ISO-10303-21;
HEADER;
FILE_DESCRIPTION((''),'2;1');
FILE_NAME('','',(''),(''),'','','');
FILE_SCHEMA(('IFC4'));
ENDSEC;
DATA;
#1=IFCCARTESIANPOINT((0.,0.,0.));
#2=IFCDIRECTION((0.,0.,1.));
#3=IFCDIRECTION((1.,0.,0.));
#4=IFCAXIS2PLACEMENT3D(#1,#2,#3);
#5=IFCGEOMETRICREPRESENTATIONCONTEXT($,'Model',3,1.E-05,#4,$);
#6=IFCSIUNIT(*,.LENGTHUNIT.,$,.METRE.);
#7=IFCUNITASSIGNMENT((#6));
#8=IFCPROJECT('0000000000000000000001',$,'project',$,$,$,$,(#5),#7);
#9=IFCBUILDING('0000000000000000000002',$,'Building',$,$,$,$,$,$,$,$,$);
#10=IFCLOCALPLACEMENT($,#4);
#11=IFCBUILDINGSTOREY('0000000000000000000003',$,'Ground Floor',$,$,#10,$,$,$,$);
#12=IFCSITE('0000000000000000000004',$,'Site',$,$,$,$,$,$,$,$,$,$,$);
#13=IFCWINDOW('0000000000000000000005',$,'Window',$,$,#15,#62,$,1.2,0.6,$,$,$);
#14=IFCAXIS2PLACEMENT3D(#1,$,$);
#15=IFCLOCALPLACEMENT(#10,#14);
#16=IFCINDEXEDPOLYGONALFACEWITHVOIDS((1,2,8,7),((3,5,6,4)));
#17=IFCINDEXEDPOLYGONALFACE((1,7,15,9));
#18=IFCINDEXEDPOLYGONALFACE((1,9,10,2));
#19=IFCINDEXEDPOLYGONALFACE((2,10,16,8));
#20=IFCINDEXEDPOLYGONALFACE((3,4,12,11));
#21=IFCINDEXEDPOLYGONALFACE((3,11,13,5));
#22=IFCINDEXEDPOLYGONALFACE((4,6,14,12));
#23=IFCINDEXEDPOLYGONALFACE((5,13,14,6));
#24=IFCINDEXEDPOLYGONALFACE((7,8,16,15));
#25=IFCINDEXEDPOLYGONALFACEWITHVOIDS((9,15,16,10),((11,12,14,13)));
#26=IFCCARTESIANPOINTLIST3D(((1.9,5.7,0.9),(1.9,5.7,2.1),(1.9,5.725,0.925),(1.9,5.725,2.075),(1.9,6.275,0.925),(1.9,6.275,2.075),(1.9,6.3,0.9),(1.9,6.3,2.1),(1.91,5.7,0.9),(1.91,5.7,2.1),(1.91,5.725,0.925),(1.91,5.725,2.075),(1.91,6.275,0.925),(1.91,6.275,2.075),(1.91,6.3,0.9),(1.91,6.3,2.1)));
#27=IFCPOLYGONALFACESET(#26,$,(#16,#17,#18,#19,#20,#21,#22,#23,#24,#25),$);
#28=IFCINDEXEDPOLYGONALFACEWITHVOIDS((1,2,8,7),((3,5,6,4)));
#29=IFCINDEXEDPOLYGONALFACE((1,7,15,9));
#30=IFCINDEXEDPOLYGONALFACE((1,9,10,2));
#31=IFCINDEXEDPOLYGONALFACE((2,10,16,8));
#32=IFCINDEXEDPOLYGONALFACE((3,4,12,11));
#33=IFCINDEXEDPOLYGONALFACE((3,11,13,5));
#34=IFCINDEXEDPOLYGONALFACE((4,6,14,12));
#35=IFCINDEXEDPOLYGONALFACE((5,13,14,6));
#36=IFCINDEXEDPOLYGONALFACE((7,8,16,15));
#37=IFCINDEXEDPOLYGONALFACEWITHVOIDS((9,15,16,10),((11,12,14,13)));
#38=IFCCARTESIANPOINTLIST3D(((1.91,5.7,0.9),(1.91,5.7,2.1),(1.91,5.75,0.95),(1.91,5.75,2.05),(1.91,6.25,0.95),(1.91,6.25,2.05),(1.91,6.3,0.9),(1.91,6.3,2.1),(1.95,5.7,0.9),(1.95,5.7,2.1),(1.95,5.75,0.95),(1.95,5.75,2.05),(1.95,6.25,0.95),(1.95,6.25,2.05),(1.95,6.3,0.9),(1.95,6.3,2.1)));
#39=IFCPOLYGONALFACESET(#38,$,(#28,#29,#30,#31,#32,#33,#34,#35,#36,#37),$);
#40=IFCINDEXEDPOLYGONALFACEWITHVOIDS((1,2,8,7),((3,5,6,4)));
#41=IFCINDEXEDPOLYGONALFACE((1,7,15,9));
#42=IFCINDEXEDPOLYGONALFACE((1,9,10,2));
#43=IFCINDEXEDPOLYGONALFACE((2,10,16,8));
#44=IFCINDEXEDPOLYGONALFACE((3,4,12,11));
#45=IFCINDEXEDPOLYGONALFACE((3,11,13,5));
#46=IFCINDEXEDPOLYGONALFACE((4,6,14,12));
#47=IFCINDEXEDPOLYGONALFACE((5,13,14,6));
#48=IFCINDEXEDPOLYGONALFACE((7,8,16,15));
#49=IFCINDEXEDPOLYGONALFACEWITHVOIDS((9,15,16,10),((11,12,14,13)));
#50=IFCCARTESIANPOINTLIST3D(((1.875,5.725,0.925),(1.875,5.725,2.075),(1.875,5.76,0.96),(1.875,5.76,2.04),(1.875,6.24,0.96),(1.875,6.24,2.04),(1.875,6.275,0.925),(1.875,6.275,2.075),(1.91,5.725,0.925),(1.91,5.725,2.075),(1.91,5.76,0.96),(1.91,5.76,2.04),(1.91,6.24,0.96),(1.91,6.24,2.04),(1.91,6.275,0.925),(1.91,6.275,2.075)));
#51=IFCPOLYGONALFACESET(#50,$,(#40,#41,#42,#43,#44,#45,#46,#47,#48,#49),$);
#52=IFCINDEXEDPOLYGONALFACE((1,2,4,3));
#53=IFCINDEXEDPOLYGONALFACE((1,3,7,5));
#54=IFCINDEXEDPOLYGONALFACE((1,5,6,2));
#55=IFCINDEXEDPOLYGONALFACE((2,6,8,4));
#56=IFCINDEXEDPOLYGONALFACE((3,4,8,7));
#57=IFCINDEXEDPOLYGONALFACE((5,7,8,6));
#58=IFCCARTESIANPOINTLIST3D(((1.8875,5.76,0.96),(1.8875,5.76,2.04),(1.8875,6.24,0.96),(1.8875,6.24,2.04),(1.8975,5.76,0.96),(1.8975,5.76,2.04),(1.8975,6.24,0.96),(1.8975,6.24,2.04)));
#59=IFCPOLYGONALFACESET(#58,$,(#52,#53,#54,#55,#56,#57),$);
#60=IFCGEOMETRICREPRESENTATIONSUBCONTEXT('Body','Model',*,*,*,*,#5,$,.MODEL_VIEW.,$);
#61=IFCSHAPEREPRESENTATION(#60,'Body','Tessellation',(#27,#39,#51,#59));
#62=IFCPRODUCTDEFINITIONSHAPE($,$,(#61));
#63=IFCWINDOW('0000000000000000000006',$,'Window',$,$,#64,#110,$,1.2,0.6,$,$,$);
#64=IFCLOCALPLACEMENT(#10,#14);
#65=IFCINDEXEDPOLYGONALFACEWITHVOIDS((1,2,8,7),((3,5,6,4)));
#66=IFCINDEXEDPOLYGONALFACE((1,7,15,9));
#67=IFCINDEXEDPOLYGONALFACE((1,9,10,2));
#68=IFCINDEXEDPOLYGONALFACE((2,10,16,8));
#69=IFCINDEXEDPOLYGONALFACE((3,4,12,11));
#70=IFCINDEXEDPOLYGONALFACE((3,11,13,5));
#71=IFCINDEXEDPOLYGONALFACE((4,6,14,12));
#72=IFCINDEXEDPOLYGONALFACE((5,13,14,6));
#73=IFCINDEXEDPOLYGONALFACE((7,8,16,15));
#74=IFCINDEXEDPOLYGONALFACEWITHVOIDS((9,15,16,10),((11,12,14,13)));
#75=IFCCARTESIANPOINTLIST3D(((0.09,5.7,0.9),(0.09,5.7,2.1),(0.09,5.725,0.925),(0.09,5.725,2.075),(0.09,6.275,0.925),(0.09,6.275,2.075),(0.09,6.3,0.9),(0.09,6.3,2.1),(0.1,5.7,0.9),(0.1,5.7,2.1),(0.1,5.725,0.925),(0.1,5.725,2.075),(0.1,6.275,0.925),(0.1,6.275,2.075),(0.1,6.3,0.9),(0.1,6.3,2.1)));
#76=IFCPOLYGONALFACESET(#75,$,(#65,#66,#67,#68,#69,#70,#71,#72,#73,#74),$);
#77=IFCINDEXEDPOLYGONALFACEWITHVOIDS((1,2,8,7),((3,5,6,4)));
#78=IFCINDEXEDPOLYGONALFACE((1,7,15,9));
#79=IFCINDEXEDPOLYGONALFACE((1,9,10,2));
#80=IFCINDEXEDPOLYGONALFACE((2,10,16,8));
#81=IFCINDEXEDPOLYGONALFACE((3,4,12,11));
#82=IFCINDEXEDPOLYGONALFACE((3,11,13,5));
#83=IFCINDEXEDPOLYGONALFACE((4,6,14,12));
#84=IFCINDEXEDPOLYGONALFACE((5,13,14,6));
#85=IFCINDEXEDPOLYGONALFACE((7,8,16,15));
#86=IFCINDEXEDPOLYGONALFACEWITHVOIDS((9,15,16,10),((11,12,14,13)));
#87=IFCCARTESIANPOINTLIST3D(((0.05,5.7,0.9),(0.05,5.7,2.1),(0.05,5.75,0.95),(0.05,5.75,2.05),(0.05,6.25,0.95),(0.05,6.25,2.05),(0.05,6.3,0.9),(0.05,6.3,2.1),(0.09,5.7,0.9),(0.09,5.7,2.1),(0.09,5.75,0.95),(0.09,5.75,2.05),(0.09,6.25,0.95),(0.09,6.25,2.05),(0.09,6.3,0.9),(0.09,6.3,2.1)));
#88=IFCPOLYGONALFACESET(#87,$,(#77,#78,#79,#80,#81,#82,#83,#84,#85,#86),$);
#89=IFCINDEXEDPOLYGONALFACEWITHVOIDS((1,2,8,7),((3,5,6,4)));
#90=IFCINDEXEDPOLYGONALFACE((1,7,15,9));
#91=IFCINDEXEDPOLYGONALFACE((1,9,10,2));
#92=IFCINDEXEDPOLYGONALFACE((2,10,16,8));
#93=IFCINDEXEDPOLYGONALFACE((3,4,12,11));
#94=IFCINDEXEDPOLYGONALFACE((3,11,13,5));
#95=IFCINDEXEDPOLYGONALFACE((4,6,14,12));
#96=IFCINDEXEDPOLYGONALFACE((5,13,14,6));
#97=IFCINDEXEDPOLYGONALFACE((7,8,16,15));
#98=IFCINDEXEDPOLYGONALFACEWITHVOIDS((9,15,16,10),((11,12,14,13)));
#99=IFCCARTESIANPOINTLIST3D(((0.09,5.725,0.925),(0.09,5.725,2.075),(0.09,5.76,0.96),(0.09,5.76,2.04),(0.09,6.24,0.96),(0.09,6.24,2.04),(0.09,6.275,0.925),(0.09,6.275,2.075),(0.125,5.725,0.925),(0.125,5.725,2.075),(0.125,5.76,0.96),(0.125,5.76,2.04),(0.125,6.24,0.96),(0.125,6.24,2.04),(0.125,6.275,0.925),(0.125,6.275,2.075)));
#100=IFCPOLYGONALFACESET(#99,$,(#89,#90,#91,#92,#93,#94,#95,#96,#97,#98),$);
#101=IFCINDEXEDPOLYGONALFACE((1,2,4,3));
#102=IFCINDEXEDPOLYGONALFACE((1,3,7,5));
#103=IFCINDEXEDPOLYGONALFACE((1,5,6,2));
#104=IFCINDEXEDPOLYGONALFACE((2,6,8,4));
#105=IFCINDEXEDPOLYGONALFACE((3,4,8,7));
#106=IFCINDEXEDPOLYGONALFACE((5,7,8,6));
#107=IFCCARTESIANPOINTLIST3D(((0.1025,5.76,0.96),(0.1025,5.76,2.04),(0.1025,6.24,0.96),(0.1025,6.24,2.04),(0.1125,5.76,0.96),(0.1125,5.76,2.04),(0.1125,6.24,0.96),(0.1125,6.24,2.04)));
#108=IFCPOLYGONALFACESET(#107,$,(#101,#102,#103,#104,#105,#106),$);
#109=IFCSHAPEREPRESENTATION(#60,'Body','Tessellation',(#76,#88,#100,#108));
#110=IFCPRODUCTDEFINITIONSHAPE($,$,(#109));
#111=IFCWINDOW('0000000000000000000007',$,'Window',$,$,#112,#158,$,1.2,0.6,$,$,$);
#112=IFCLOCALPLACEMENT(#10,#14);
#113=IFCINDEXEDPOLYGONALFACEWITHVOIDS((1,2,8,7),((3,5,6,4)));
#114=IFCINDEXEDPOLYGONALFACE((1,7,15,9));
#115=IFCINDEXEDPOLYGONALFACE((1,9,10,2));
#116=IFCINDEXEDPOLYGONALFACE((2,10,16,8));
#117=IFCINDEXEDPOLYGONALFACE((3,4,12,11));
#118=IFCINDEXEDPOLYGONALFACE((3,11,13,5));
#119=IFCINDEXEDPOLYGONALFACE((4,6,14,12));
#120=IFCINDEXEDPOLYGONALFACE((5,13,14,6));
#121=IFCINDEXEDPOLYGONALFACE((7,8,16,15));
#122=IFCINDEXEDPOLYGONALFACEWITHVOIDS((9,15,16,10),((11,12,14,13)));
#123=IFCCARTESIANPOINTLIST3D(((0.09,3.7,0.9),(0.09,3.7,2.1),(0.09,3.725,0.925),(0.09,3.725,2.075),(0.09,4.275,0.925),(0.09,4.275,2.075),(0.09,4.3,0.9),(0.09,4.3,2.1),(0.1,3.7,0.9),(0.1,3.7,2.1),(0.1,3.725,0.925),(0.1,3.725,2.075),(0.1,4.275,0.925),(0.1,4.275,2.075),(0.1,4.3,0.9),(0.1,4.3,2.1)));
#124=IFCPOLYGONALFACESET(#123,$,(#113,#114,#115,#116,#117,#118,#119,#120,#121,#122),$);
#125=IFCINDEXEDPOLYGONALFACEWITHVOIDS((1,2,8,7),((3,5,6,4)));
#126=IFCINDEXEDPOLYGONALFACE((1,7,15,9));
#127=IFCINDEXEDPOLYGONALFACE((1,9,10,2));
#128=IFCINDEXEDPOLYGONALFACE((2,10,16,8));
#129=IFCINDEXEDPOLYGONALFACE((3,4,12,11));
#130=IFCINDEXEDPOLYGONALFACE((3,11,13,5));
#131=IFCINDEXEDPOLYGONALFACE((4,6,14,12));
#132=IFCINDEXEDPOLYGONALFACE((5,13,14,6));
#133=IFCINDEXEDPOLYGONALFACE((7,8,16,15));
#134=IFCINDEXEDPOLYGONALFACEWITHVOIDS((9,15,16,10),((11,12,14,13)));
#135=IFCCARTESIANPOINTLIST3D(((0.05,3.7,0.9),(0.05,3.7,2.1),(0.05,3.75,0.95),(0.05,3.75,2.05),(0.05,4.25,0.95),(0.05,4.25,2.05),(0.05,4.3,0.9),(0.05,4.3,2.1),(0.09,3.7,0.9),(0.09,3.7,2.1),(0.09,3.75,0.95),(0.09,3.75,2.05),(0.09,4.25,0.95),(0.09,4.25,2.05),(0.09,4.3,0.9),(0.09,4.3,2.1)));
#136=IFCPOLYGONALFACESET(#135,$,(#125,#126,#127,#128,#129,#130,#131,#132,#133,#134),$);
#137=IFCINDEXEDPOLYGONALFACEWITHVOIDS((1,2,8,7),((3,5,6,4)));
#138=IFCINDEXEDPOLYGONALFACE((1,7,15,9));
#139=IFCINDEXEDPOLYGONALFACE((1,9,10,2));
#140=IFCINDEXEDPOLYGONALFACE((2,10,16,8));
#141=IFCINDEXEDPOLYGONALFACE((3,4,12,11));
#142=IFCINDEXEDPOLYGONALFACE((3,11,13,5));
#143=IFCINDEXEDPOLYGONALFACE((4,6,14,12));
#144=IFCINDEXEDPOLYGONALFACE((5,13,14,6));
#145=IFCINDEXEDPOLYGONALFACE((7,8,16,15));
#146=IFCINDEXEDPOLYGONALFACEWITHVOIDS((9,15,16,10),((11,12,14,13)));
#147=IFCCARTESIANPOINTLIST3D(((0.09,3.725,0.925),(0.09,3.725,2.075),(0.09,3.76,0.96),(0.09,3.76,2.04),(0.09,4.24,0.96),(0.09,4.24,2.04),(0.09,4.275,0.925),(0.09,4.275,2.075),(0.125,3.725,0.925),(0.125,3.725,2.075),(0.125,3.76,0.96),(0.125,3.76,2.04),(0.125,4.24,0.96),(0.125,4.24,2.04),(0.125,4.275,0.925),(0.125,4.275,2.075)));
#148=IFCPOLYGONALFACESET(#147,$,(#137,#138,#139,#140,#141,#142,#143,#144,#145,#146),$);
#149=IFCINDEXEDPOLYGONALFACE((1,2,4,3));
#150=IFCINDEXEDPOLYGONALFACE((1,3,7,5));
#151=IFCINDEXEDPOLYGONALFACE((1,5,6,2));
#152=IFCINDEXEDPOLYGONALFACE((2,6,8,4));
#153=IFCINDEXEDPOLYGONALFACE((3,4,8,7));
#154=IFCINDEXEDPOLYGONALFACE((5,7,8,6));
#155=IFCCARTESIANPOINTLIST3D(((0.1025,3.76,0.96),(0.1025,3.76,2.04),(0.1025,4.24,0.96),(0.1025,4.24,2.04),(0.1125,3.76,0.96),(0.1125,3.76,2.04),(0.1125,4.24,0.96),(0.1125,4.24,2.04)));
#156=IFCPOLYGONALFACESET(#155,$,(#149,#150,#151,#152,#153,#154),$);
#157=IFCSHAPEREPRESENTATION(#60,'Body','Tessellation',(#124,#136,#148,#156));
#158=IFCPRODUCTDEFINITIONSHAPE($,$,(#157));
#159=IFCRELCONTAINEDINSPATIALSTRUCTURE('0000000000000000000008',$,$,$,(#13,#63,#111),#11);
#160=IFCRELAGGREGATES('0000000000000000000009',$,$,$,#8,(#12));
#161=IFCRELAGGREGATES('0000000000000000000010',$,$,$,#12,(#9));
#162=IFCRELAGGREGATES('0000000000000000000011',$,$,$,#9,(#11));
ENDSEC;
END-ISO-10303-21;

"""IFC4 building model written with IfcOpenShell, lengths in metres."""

from ifc_helpers import new_model, si_unit, frame, origin_with_axes, place, context, subcontext, project, spatial, line, indexed_curve, outline, extrude, element, save


model = new_model("IFC4")

# Units and contexts
model_context = context("Model", 3, precision=1e-05, world=origin_with_axes())
body_context = subcontext(model_context, "Body", "Model", "MODEL_VIEW")
ifc_project = project(units=[si_unit("LENGTHUNIT", "METRE")], contexts=[model_context])

# Site, building, storey
site = spatial("IfcSite", under=ifc_project, Name="Site")
building = spatial("IfcBuilding", under=site, Name="Building")
storey_placement = place(None, origin_with_axes())
storey = spatial("IfcBuildingStorey", under=building, at=storey_placement, Name="Ground Floor")

# Windows
for number, where, z_axis, x_axis, name in (
    (1, (2.0, 5.7, 0.9), (0.0, 0.0, 1.0), (0.0, 1.0, 0.0), "Window"),
    (2, (0.0, 6.3, 0.9), (0.0, 0.0, 1.0), (0.0, -1.0, 0.0), "Window"),
    (3, (0.0, 4.3, 0.9), (0.0, 0.0, 1.0), (0.0, -1.0, 0.0), "Window"),
):
    element("IfcWindow", number, at=place(storey_placement, frame(where, z_axis=z_axis, x_axis=x_axis)), inside=storey, Name=name, OverallHeight=1.2, OverallWidth=0.6, context=body_context, shape_type="SweptSolid", body=[
        extrude(outline(indexed_curve([(0.0, 0.0), (0.6, 0.0), (0.6, 1.2), (0.0, 1.2)], segments=[line(1, 2, 3, 4, 1)]), holes=[indexed_curve([(0.025, 0.025), (0.575, 0.025), (0.575, 1.175), (0.025, 1.175)], segments=[line(1, 2, 3, 4, 1)])]), frame((0.0, 0.09, 0.0), z_axis=(0.0, -1.0, 0.0), x_axis=(1.0, 0.0, 0.0)), (0.0, 0.0, -1.0), 0.01),
        extrude(outline(indexed_curve([(0.0, 0.0), (0.6, 0.0), (0.6, 1.2), (0.0, 1.2)], segments=[line(1, 2, 3, 4, 1)]), holes=[indexed_curve([(0.05, 0.05), (0.55, 0.05), (0.55, 1.15), (0.05, 1.15)], segments=[line(1, 2, 3, 4, 1)])]), frame((0.0, 0.05, 0.0), z_axis=(0.0, -1.0, 0.0), x_axis=(1.0, 0.0, 0.0)), (0.0, 0.0, -1.0), 0.04),
        extrude(outline(indexed_curve([(0.0, 0.0), (0.55, 0.0), (0.55, 1.15), (0.0, 1.15)], segments=[line(1, 2, 3, 4, 1)]), holes=[indexed_curve([(0.035, 0.035), (0.515, 0.035), (0.515, 1.115), (0.035, 1.115)], segments=[line(1, 2, 3, 4, 1)])]), frame((0.025, 0.09, 0.025), z_axis=(0.0, -1.0, 0.0), x_axis=(1.0, 0.0, 0.0)), (0.0, 0.0, -1.0), 0.035),
        extrude(outline(indexed_curve([(0.035, 0.035), (0.515, 0.035), (0.515, 1.115), (0.035, 1.115)], segments=[line(1, 2, 3, 4, 1)])), frame((0.025, 0.1025, 0.025), z_axis=(0.0, -1.0, 0.0), x_axis=(1.0, 0.0, 0.0)), (0.0, 0.0, -1.0), 0.01),
    ])

save(model, "model.ifc")
